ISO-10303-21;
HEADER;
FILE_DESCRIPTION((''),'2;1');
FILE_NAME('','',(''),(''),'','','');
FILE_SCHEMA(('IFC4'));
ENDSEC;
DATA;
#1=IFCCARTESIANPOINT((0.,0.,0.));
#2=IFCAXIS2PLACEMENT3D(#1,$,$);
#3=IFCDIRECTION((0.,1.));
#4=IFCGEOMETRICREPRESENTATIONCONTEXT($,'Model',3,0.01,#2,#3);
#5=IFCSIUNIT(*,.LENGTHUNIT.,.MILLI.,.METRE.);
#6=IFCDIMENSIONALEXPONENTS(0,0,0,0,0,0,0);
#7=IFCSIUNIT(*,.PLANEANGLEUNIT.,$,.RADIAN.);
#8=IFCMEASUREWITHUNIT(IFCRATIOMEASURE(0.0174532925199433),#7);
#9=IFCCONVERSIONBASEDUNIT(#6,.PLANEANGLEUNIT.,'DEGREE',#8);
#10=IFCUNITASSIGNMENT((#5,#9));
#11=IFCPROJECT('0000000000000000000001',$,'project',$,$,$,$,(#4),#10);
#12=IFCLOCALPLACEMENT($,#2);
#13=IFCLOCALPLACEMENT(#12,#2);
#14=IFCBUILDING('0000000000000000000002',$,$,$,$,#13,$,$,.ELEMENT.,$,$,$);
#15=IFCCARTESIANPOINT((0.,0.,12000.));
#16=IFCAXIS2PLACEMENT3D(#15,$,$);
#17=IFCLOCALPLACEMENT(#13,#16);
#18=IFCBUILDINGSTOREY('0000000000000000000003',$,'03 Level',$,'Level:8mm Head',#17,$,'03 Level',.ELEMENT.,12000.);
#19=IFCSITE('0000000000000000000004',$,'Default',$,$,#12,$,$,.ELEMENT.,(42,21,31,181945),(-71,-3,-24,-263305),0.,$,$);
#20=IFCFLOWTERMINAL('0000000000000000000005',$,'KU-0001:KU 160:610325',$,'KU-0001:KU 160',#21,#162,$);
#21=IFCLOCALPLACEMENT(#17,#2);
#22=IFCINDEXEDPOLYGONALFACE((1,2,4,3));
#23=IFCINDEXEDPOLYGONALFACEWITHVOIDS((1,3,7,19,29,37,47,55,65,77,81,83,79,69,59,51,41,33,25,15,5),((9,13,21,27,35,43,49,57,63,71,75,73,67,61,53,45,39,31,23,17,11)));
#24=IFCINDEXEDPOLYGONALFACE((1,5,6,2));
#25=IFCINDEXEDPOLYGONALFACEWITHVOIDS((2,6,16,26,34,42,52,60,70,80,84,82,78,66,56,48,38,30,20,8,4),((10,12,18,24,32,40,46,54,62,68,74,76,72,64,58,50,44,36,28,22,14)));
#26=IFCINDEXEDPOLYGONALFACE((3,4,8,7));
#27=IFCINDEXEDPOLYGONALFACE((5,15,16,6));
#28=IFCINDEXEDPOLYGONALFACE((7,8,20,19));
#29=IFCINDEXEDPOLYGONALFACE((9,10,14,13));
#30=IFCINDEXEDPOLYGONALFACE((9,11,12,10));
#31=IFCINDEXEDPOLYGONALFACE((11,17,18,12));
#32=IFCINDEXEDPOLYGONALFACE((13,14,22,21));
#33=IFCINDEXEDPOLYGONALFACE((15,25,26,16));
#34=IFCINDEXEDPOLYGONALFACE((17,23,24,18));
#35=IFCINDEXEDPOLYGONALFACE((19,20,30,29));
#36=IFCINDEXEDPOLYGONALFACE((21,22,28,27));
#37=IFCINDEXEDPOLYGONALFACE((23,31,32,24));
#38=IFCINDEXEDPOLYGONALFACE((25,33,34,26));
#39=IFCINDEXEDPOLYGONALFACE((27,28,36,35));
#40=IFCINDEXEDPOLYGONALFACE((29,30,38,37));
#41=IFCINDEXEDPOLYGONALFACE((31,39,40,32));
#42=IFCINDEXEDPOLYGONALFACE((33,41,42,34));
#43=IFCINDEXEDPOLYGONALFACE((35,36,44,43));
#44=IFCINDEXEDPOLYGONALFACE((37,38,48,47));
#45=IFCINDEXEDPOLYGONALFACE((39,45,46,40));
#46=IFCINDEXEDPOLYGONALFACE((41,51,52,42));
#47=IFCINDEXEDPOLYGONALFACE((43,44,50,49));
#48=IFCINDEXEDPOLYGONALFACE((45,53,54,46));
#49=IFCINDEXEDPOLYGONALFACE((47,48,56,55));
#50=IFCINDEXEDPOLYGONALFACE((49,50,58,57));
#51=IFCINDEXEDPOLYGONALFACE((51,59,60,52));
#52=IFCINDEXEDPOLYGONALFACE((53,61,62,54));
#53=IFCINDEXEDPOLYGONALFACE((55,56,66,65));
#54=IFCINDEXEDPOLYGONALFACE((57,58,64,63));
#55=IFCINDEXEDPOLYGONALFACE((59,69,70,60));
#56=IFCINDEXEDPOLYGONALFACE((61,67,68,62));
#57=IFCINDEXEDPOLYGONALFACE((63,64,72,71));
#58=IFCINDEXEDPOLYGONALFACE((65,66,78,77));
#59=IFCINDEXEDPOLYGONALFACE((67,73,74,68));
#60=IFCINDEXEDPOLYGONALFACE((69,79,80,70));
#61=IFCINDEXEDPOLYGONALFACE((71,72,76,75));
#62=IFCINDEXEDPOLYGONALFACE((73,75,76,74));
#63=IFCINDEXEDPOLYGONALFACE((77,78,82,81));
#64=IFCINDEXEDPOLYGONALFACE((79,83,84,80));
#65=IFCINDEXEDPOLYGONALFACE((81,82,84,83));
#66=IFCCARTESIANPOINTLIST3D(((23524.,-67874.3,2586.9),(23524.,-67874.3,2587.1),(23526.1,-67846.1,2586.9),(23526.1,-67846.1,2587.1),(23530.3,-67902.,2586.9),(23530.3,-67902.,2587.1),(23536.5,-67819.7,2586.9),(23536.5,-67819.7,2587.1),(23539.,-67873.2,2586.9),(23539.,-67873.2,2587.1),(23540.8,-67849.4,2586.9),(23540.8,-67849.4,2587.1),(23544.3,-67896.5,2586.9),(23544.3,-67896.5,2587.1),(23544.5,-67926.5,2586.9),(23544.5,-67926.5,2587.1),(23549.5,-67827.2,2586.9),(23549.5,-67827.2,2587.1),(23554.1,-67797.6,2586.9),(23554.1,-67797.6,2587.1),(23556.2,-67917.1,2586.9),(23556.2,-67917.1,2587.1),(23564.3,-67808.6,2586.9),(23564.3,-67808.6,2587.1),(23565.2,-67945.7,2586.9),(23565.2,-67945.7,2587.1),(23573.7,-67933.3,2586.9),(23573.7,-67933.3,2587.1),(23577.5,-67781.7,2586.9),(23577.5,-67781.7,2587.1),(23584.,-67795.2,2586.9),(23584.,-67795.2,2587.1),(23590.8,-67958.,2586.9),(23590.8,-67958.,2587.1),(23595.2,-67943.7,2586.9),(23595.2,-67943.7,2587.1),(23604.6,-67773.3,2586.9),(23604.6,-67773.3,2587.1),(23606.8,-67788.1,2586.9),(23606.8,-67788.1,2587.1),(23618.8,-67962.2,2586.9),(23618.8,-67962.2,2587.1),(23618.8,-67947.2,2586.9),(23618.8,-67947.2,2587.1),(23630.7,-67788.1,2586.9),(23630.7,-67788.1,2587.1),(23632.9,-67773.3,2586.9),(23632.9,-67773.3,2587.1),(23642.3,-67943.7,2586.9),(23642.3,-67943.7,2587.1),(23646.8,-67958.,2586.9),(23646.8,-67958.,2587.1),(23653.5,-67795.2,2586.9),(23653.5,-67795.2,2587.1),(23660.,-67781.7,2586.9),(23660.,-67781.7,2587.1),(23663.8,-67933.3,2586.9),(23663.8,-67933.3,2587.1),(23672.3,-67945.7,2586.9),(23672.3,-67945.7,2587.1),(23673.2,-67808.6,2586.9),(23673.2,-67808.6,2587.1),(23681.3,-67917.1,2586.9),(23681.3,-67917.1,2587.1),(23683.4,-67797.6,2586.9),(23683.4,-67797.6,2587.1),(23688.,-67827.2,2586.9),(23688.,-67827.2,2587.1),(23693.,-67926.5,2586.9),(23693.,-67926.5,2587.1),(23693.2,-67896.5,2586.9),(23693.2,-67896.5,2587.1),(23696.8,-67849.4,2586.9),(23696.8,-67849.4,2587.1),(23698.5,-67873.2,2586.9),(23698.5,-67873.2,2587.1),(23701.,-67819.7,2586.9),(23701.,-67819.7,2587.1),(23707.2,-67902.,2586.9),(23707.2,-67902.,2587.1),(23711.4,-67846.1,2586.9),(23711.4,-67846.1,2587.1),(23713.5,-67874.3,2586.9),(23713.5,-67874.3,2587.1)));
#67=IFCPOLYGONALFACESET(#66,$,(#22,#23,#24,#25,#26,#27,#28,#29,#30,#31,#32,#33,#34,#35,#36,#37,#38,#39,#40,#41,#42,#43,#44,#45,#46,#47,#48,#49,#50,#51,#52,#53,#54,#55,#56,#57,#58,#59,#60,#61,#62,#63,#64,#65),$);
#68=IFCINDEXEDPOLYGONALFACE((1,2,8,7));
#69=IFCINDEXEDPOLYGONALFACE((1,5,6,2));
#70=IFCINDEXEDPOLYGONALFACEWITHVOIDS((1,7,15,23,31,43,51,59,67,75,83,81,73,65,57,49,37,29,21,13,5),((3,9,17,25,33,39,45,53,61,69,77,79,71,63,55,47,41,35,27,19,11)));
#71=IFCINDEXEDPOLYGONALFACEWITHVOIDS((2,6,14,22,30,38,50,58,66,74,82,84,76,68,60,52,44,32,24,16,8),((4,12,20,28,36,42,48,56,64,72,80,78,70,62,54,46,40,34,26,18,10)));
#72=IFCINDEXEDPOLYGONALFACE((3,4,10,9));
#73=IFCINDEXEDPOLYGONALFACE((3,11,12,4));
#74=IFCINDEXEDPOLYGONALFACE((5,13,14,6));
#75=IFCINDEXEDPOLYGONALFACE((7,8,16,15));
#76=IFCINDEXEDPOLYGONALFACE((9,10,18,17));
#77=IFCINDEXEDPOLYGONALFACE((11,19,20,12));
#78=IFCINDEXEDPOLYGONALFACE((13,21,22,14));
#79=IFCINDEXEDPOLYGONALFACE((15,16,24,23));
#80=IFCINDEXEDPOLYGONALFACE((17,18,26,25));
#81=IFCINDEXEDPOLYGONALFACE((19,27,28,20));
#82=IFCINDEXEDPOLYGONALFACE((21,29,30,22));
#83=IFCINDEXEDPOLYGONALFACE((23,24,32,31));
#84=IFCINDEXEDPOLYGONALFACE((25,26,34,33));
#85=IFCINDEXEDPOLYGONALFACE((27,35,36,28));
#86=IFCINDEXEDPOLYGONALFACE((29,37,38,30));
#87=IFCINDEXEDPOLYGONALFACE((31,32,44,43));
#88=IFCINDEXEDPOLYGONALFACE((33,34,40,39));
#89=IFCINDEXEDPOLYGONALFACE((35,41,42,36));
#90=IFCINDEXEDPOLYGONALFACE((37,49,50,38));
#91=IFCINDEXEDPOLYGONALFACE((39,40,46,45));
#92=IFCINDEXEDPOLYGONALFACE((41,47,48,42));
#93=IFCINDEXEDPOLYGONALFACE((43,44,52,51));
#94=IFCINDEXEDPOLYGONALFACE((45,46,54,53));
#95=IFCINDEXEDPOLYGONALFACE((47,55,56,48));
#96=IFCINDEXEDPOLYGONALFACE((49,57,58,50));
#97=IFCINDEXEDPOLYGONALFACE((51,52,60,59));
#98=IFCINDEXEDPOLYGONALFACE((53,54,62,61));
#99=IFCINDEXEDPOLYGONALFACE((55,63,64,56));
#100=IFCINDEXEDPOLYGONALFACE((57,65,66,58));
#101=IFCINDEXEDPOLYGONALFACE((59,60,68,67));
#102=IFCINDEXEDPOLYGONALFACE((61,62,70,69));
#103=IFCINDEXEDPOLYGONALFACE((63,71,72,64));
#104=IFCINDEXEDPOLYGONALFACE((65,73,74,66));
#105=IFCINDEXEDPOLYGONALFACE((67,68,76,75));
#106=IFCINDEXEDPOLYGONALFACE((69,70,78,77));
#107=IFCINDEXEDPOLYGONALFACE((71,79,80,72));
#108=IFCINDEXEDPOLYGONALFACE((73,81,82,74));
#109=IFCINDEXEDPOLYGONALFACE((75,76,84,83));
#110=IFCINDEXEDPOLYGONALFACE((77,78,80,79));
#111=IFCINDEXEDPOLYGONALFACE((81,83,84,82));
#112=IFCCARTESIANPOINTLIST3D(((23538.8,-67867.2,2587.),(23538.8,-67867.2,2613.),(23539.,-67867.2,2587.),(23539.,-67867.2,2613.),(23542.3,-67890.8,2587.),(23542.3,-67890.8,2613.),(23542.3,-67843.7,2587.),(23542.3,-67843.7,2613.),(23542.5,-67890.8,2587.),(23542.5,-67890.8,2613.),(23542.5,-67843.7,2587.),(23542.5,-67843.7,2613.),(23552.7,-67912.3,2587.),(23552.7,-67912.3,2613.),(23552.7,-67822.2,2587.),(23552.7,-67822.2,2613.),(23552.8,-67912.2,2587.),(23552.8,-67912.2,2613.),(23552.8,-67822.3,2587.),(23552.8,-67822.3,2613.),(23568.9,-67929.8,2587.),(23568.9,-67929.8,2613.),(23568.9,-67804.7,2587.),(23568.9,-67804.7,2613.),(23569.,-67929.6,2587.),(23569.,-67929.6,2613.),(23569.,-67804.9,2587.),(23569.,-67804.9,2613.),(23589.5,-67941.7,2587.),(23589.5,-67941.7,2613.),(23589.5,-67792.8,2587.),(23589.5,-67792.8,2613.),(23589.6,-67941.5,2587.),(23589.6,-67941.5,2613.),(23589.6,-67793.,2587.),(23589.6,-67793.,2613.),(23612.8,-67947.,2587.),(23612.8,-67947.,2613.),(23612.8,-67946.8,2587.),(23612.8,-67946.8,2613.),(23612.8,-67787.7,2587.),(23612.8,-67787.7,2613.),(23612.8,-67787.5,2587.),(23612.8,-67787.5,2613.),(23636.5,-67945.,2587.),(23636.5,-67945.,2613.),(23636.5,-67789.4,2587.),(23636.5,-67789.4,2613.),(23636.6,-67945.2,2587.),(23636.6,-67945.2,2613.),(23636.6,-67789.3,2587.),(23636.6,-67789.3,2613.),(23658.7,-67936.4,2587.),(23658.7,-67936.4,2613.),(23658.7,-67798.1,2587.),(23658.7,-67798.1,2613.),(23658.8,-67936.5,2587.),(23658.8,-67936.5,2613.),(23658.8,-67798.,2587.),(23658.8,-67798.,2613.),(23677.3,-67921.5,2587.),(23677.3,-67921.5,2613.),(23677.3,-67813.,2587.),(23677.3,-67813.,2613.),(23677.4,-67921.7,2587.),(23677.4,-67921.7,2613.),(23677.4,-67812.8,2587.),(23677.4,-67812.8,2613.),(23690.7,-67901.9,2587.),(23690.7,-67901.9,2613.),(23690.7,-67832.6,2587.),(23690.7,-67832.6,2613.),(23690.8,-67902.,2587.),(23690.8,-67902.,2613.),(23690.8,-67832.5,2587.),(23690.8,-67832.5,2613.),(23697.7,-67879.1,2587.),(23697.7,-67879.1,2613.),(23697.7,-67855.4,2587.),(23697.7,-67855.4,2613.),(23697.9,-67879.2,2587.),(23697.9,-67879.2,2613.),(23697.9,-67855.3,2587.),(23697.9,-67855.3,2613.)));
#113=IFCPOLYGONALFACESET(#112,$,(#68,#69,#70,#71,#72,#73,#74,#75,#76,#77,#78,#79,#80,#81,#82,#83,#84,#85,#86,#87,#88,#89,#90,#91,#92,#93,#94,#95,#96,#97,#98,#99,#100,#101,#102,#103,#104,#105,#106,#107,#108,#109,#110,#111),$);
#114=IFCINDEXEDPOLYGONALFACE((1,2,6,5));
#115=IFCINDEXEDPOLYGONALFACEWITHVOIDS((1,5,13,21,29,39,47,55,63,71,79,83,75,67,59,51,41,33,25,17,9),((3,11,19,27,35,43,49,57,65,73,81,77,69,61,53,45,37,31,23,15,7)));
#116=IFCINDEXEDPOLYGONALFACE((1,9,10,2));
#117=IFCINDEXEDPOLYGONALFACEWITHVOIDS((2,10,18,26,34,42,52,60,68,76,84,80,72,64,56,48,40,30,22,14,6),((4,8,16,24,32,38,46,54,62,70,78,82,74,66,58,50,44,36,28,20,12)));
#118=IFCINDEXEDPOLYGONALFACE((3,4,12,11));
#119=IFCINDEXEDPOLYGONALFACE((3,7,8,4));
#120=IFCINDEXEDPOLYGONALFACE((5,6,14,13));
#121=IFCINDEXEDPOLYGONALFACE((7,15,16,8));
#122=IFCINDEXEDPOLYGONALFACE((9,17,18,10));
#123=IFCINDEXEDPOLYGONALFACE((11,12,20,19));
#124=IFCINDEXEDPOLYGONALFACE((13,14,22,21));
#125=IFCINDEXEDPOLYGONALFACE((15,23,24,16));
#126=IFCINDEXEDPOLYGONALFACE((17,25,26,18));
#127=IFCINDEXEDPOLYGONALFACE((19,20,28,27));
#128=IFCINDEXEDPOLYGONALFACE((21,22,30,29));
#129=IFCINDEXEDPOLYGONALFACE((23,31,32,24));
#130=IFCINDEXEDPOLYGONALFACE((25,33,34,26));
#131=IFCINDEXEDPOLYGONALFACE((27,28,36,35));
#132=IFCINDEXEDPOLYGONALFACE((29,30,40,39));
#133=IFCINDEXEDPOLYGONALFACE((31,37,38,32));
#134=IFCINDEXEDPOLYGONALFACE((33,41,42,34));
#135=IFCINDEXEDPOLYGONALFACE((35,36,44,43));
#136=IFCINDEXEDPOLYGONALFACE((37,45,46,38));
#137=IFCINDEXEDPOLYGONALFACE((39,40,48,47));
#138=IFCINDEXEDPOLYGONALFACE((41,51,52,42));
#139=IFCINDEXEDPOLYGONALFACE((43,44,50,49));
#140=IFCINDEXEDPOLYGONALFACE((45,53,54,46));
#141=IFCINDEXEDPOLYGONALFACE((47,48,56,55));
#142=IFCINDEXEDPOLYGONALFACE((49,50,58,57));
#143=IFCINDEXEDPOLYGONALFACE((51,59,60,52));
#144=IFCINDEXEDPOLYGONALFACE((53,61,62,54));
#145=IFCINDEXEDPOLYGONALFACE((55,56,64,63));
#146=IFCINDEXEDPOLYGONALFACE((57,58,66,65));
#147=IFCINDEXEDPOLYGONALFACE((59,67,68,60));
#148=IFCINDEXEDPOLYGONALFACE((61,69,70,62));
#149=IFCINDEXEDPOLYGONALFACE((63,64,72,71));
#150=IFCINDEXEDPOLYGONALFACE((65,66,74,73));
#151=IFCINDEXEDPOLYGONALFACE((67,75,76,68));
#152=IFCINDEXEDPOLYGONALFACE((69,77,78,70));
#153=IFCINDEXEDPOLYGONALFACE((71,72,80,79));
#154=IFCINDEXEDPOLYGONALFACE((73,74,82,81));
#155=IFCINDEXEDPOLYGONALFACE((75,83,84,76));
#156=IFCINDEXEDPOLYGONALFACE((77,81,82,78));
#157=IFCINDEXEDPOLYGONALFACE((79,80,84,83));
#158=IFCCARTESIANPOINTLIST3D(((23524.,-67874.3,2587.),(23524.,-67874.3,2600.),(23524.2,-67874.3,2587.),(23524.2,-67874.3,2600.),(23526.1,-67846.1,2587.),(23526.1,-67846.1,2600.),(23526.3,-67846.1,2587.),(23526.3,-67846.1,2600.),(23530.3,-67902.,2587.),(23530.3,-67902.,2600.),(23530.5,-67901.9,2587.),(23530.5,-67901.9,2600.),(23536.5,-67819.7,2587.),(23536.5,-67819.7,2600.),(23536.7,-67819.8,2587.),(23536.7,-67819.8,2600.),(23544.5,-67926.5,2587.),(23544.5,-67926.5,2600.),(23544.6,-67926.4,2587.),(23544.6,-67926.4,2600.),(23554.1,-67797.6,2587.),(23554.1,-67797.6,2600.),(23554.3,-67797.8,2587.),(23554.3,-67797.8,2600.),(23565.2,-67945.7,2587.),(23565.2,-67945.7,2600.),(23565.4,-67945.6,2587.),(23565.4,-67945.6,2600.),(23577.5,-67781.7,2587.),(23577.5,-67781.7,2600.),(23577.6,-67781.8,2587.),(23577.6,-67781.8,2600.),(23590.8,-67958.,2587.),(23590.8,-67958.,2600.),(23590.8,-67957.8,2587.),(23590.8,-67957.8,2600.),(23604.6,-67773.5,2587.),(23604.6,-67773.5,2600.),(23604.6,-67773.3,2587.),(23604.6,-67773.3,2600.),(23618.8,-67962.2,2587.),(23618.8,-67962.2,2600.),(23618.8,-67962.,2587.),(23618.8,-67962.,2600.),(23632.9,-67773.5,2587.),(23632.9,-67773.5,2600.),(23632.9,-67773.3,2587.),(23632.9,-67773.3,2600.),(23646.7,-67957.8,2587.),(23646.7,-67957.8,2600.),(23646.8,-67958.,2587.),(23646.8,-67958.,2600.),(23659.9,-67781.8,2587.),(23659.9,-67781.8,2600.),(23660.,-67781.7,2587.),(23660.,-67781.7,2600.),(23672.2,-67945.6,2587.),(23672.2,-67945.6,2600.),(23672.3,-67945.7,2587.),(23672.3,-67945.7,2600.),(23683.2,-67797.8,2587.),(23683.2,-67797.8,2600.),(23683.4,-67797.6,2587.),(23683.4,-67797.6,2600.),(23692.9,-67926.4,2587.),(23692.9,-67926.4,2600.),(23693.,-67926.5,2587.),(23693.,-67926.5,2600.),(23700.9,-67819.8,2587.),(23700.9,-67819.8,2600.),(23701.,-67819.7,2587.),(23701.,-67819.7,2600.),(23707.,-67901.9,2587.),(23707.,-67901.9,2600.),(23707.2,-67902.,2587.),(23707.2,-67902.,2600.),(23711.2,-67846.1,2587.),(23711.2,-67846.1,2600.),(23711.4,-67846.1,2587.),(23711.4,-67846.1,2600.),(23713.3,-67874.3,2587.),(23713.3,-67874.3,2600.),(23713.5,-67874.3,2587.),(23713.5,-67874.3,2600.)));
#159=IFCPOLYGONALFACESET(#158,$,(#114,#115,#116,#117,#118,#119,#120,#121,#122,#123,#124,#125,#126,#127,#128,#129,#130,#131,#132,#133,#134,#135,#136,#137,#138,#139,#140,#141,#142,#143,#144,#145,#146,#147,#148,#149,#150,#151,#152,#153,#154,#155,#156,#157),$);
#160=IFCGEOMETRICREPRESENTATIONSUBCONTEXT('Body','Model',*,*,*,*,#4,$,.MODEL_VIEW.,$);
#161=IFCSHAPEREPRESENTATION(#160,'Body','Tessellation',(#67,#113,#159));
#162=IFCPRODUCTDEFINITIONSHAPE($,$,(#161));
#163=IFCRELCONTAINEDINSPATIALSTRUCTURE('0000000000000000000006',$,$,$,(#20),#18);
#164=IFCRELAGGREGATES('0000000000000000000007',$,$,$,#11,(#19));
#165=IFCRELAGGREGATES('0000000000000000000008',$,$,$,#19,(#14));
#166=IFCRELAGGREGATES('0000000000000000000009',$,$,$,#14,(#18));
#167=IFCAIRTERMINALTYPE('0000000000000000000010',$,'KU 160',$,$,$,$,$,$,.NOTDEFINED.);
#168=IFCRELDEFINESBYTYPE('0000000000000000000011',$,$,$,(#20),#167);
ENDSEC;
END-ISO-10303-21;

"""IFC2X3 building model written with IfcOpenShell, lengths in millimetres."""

from ifc_helpers import new_model, entity, si_unit, converted_unit, direction, frame, frame_2d, origin, place, context, subcontext, project, spatial, hollow_circle, extrude, source, transform, mapped, type_object, type_shapes, element, save


model = new_model("IFC2X3")

# Units and contexts
model_context = context("Model", 3, precision=0.01, world=origin(), true_north=direction((0.0, 1.0)))
body_context = subcontext(model_context, "Body", "Model", "MODEL_VIEW")
ifc_project = project(units=[si_unit("LENGTHUNIT", "METRE", prefix="MILLI"), converted_unit("PLANEANGLEUNIT", "DEGREE", entity("IfcRatioMeasure", 0.0174532925199433), si_unit("PLANEANGLEUNIT", "RADIAN"), dimensions=[0, 0, 0, 0, 0, 0, 0])], contexts=[model_context])

# Site, building, storey
site_placement = place(None, origin())
site = spatial("IfcSite", under=ifc_project, at=site_placement, Name="Default", CompositionType="ELEMENT", RefLatitude=(42, 21, 31, 181945), RefLongitude=(-71, -3, -24, -263305), RefElevation=0.0)
building_placement = place(site_placement, origin())
building = spatial("IfcBuilding", under=site, at=building_placement, CompositionType="ELEMENT")
storey_placement = place(building_placement, frame((0.0, 0.0, 12000.0)))
storey = spatial("IfcBuildingStorey", under=building, at=storey_placement, Name="03 Level", ObjectType="Level:8mm Head", LongName="03 Level", CompositionType="ELEMENT", Elevation=12000.0)

# Flow terminal
air_terminal_type_1 = type_object("IfcAirTerminalType", Name="KU 160", PredefinedType="NOTDEFINED")
shared_shape_1 = source(origin(), body_context, "Body", "SweptSolid", [
    extrude(hollow_circle(Radius=95.0, WallThickness=15.0, at=frame_2d((0.0, 0.0), x_axis=(1.0, 0.0))), frame((12.9, 0.0, 0.0), z_axis=(1.0, 0.0, 0.0), x_axis=(0.0, -1.0, 0.0)), (0.0, 0.0, 1.0), 0.2),
    extrude(hollow_circle(Radius=80.0, WallThickness=0.2, at=frame_2d((0.0, 0.0), x_axis=(1.0, 0.0))), frame((-13.0, 0.0, 0.0), z_axis=(1.0, 0.0, 0.0), x_axis=(0.0, 0.0, -1.0)), (0.0, 0.0, 1.0), 26.0),
    extrude(hollow_circle(Radius=95.0, WallThickness=0.2, at=frame_2d((0.0, 0.0), x_axis=(1.0, 0.0))), frame((0.0, 0.0, 0.0), z_axis=(1.0, 0.0, 0.0), x_axis=(0.0, -1.0, 0.0)), (0.0, 0.0, 1.0), 13.0),
])
type_shapes(air_terminal_type_1, [shared_shape_1])
for number, where, z_axis, x_axis, name in (
    (1, (23618.8, -67867.2, 2600.0), (1.0, 0.0, 0.0), (0.0, 0.0, -1.0), "KU-0001:KU 160:610325"),
):
    element("IfcFlowTerminal", number, at=place(storey_placement, frame(where, z_axis=z_axis, x_axis=x_axis)), inside=storey, type_object=air_terminal_type_1, Name=name, ObjectType="KU-0001:KU 160", context=body_context, shape_type="MappedRepresentation", body=[
        mapped(shared_shape_1, transform((0.0, 0.0, 0.0), scale=1.0)),
    ])

save(model, "model.ifc")
